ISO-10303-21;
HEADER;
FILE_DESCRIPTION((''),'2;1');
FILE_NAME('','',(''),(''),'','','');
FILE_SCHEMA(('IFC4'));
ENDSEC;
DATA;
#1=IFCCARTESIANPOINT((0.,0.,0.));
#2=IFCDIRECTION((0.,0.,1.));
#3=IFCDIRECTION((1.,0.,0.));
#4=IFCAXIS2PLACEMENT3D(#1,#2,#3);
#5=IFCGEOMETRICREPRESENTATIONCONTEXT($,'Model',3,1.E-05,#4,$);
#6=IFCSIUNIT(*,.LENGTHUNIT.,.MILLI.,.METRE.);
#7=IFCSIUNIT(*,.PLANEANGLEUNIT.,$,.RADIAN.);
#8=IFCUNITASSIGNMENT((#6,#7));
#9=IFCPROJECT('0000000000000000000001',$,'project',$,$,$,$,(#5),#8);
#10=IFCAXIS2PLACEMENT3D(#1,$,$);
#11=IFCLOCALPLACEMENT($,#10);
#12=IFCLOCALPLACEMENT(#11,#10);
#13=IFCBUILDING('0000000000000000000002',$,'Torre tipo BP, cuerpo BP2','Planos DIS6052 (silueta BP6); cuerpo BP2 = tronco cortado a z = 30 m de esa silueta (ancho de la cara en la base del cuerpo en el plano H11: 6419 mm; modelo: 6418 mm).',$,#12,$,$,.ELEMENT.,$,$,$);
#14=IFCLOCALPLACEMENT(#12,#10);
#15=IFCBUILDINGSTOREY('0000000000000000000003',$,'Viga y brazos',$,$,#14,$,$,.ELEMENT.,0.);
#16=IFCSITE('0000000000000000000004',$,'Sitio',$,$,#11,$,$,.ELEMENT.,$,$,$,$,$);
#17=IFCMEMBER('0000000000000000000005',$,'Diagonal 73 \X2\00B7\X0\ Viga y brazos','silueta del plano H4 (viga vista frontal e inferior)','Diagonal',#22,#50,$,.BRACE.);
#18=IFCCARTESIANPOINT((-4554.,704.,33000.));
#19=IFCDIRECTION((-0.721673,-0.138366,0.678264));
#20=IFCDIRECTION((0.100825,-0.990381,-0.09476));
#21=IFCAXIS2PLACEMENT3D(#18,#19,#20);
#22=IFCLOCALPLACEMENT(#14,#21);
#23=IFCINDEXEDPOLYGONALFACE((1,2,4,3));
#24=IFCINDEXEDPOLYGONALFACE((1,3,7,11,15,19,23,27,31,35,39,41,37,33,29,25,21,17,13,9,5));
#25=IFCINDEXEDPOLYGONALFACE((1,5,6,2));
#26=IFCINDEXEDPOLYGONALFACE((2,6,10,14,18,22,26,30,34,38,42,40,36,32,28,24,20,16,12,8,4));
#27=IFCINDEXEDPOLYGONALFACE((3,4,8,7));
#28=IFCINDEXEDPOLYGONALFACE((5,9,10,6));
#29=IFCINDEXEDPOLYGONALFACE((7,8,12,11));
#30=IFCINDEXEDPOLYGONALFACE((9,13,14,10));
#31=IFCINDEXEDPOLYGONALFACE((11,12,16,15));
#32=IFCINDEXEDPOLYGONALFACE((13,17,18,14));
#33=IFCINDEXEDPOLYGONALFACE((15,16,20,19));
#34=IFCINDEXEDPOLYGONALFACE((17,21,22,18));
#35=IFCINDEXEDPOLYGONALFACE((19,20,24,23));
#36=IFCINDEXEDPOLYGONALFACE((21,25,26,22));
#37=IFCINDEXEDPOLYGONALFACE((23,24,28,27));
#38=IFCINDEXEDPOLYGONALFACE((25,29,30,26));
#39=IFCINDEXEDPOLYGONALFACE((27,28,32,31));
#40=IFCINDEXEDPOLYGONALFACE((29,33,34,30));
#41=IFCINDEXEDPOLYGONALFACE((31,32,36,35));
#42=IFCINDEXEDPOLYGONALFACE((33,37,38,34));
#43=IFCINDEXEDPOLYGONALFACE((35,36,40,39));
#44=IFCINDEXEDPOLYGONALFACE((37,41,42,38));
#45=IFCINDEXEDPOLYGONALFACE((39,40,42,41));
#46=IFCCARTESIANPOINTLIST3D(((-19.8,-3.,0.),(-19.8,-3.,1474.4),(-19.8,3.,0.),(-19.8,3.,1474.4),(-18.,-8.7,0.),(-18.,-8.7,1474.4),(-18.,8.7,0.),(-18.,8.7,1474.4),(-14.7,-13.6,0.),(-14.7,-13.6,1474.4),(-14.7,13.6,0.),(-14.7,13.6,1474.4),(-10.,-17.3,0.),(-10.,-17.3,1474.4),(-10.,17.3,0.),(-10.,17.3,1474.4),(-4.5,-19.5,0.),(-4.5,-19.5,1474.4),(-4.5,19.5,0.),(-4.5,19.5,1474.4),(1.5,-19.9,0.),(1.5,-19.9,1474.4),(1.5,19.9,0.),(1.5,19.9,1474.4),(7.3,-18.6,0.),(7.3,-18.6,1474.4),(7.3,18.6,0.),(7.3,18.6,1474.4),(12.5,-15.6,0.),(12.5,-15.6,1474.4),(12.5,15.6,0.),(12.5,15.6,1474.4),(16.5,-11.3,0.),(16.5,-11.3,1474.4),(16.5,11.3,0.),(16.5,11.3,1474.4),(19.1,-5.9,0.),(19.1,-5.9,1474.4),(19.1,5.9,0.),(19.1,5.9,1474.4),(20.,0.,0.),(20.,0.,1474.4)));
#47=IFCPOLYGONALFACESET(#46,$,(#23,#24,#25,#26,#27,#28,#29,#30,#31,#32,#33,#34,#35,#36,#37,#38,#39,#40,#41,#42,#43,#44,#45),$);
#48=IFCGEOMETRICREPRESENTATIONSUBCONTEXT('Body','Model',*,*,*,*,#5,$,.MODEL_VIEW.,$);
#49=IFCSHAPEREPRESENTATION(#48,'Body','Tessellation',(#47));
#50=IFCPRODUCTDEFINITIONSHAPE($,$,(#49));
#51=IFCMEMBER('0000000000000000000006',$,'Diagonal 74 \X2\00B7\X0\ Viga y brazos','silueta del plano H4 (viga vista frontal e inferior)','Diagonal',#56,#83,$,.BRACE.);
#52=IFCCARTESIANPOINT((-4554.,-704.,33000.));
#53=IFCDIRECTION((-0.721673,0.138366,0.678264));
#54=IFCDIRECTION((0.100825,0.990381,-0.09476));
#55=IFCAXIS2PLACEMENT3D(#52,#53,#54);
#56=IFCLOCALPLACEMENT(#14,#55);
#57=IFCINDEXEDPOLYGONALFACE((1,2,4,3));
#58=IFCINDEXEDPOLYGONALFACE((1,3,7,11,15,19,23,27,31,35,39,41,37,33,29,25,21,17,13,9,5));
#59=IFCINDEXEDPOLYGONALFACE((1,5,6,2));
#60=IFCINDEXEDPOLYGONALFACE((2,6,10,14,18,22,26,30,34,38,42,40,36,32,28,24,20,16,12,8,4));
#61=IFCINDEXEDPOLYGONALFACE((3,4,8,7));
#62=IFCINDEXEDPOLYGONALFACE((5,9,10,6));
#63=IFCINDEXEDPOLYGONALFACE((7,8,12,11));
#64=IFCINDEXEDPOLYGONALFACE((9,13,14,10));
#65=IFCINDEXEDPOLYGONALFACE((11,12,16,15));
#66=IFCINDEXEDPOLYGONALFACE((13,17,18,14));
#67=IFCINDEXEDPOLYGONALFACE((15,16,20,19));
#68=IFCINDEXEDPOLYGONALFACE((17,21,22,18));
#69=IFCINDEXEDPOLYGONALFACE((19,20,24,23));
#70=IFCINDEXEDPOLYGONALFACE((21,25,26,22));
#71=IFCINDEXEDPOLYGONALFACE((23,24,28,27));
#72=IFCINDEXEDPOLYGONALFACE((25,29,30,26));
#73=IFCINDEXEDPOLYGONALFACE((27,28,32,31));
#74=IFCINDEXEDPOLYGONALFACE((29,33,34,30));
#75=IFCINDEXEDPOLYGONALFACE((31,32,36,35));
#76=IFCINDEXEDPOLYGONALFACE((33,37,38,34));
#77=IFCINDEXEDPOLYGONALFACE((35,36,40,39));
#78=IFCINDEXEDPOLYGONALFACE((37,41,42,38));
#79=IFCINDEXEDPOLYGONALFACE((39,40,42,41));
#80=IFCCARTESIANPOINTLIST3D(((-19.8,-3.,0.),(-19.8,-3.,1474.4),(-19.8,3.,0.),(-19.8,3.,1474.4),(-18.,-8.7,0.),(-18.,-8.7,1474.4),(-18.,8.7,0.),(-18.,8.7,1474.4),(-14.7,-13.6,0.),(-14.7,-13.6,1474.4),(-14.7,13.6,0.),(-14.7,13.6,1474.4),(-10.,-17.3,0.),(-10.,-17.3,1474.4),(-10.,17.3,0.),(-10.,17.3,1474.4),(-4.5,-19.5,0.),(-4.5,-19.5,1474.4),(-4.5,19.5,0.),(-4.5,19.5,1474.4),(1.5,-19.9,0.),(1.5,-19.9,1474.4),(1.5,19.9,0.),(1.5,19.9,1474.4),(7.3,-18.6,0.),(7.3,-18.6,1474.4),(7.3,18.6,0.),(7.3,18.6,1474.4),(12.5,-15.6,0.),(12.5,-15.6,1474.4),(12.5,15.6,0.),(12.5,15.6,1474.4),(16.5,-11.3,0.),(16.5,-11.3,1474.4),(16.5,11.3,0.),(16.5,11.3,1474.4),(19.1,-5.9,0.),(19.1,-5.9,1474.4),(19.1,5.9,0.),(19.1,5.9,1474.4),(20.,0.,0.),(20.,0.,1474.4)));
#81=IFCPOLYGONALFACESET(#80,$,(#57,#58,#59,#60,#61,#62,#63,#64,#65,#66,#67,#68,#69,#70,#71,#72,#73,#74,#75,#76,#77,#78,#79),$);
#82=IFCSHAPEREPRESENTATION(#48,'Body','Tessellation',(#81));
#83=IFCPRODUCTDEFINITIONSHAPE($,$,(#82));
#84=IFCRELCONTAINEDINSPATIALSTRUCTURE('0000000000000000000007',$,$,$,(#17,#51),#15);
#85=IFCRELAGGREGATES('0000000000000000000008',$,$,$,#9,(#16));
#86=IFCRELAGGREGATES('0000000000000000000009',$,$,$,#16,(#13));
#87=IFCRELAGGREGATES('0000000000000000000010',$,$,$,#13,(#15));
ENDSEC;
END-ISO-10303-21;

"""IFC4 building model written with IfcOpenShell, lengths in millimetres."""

from ifc_helpers import new_model, si_unit, frame, origin, origin_with_axes, place, context, subcontext, project, spatial, circle, extrude, element, save


model = new_model("IFC4")

# Units and contexts
model_context = context("Model", 3, precision=1e-05, world=origin_with_axes())
body_context = subcontext(model_context, "Body", "Model", "MODEL_VIEW")
ifc_project = project(units=[si_unit("LENGTHUNIT", "METRE", prefix="MILLI"), si_unit("PLANEANGLEUNIT", "RADIAN")], contexts=[model_context])

# Site, building, storey
site_placement = place(None, origin())
site = spatial("IfcSite", under=ifc_project, at=site_placement, Name="Sitio", CompositionType="ELEMENT")
building_placement = place(site_placement, origin())
building = spatial("IfcBuilding", under=site, at=building_placement, Name="Torre tipo BP, cuerpo BP2", Description="Planos DIS6052 (silueta BP6); cuerpo BP2 = tronco cortado a z = 30 m de esa silueta (ancho de la cara en la base del cuerpo en el plano H11: 6419 mm; modelo: 6418 mm).", CompositionType="ELEMENT")
storey_placement = place(building_placement, origin())
storey = spatial("IfcBuildingStorey", under=building, at=storey_placement, Name="Viga y brazos", CompositionType="ELEMENT", Elevation=0.0)

# Members
for number, where, z_axis, x_axis, name in (
    (1, (-4554.0, 704.0, 33000.0), (-0.721673, -0.138366, 0.678264), (0.100825, -0.990381, -0.09476), "Diagonal 73 · Viga y brazos"),
    (2, (-4554.0, -704.0, 33000.0), (-0.721673, 0.138366, 0.678264), (0.100825, 0.990381, -0.09476), "Diagonal 74 · Viga y brazos"),
):
    element("IfcMember", number, at=place(storey_placement, frame(where, z_axis=z_axis, x_axis=x_axis)), inside=storey, Name=name, Description="silueta del plano H4 (viga vista frontal e inferior)", ObjectType="Diagonal", PredefinedType="BRACE", context=body_context, shape_type="SweptSolid", body=[
        extrude(circle(Radius=20.0), None, (0.0, 0.0, 1.0), 1474.4),
    ])

save(model, "model.ifc")
